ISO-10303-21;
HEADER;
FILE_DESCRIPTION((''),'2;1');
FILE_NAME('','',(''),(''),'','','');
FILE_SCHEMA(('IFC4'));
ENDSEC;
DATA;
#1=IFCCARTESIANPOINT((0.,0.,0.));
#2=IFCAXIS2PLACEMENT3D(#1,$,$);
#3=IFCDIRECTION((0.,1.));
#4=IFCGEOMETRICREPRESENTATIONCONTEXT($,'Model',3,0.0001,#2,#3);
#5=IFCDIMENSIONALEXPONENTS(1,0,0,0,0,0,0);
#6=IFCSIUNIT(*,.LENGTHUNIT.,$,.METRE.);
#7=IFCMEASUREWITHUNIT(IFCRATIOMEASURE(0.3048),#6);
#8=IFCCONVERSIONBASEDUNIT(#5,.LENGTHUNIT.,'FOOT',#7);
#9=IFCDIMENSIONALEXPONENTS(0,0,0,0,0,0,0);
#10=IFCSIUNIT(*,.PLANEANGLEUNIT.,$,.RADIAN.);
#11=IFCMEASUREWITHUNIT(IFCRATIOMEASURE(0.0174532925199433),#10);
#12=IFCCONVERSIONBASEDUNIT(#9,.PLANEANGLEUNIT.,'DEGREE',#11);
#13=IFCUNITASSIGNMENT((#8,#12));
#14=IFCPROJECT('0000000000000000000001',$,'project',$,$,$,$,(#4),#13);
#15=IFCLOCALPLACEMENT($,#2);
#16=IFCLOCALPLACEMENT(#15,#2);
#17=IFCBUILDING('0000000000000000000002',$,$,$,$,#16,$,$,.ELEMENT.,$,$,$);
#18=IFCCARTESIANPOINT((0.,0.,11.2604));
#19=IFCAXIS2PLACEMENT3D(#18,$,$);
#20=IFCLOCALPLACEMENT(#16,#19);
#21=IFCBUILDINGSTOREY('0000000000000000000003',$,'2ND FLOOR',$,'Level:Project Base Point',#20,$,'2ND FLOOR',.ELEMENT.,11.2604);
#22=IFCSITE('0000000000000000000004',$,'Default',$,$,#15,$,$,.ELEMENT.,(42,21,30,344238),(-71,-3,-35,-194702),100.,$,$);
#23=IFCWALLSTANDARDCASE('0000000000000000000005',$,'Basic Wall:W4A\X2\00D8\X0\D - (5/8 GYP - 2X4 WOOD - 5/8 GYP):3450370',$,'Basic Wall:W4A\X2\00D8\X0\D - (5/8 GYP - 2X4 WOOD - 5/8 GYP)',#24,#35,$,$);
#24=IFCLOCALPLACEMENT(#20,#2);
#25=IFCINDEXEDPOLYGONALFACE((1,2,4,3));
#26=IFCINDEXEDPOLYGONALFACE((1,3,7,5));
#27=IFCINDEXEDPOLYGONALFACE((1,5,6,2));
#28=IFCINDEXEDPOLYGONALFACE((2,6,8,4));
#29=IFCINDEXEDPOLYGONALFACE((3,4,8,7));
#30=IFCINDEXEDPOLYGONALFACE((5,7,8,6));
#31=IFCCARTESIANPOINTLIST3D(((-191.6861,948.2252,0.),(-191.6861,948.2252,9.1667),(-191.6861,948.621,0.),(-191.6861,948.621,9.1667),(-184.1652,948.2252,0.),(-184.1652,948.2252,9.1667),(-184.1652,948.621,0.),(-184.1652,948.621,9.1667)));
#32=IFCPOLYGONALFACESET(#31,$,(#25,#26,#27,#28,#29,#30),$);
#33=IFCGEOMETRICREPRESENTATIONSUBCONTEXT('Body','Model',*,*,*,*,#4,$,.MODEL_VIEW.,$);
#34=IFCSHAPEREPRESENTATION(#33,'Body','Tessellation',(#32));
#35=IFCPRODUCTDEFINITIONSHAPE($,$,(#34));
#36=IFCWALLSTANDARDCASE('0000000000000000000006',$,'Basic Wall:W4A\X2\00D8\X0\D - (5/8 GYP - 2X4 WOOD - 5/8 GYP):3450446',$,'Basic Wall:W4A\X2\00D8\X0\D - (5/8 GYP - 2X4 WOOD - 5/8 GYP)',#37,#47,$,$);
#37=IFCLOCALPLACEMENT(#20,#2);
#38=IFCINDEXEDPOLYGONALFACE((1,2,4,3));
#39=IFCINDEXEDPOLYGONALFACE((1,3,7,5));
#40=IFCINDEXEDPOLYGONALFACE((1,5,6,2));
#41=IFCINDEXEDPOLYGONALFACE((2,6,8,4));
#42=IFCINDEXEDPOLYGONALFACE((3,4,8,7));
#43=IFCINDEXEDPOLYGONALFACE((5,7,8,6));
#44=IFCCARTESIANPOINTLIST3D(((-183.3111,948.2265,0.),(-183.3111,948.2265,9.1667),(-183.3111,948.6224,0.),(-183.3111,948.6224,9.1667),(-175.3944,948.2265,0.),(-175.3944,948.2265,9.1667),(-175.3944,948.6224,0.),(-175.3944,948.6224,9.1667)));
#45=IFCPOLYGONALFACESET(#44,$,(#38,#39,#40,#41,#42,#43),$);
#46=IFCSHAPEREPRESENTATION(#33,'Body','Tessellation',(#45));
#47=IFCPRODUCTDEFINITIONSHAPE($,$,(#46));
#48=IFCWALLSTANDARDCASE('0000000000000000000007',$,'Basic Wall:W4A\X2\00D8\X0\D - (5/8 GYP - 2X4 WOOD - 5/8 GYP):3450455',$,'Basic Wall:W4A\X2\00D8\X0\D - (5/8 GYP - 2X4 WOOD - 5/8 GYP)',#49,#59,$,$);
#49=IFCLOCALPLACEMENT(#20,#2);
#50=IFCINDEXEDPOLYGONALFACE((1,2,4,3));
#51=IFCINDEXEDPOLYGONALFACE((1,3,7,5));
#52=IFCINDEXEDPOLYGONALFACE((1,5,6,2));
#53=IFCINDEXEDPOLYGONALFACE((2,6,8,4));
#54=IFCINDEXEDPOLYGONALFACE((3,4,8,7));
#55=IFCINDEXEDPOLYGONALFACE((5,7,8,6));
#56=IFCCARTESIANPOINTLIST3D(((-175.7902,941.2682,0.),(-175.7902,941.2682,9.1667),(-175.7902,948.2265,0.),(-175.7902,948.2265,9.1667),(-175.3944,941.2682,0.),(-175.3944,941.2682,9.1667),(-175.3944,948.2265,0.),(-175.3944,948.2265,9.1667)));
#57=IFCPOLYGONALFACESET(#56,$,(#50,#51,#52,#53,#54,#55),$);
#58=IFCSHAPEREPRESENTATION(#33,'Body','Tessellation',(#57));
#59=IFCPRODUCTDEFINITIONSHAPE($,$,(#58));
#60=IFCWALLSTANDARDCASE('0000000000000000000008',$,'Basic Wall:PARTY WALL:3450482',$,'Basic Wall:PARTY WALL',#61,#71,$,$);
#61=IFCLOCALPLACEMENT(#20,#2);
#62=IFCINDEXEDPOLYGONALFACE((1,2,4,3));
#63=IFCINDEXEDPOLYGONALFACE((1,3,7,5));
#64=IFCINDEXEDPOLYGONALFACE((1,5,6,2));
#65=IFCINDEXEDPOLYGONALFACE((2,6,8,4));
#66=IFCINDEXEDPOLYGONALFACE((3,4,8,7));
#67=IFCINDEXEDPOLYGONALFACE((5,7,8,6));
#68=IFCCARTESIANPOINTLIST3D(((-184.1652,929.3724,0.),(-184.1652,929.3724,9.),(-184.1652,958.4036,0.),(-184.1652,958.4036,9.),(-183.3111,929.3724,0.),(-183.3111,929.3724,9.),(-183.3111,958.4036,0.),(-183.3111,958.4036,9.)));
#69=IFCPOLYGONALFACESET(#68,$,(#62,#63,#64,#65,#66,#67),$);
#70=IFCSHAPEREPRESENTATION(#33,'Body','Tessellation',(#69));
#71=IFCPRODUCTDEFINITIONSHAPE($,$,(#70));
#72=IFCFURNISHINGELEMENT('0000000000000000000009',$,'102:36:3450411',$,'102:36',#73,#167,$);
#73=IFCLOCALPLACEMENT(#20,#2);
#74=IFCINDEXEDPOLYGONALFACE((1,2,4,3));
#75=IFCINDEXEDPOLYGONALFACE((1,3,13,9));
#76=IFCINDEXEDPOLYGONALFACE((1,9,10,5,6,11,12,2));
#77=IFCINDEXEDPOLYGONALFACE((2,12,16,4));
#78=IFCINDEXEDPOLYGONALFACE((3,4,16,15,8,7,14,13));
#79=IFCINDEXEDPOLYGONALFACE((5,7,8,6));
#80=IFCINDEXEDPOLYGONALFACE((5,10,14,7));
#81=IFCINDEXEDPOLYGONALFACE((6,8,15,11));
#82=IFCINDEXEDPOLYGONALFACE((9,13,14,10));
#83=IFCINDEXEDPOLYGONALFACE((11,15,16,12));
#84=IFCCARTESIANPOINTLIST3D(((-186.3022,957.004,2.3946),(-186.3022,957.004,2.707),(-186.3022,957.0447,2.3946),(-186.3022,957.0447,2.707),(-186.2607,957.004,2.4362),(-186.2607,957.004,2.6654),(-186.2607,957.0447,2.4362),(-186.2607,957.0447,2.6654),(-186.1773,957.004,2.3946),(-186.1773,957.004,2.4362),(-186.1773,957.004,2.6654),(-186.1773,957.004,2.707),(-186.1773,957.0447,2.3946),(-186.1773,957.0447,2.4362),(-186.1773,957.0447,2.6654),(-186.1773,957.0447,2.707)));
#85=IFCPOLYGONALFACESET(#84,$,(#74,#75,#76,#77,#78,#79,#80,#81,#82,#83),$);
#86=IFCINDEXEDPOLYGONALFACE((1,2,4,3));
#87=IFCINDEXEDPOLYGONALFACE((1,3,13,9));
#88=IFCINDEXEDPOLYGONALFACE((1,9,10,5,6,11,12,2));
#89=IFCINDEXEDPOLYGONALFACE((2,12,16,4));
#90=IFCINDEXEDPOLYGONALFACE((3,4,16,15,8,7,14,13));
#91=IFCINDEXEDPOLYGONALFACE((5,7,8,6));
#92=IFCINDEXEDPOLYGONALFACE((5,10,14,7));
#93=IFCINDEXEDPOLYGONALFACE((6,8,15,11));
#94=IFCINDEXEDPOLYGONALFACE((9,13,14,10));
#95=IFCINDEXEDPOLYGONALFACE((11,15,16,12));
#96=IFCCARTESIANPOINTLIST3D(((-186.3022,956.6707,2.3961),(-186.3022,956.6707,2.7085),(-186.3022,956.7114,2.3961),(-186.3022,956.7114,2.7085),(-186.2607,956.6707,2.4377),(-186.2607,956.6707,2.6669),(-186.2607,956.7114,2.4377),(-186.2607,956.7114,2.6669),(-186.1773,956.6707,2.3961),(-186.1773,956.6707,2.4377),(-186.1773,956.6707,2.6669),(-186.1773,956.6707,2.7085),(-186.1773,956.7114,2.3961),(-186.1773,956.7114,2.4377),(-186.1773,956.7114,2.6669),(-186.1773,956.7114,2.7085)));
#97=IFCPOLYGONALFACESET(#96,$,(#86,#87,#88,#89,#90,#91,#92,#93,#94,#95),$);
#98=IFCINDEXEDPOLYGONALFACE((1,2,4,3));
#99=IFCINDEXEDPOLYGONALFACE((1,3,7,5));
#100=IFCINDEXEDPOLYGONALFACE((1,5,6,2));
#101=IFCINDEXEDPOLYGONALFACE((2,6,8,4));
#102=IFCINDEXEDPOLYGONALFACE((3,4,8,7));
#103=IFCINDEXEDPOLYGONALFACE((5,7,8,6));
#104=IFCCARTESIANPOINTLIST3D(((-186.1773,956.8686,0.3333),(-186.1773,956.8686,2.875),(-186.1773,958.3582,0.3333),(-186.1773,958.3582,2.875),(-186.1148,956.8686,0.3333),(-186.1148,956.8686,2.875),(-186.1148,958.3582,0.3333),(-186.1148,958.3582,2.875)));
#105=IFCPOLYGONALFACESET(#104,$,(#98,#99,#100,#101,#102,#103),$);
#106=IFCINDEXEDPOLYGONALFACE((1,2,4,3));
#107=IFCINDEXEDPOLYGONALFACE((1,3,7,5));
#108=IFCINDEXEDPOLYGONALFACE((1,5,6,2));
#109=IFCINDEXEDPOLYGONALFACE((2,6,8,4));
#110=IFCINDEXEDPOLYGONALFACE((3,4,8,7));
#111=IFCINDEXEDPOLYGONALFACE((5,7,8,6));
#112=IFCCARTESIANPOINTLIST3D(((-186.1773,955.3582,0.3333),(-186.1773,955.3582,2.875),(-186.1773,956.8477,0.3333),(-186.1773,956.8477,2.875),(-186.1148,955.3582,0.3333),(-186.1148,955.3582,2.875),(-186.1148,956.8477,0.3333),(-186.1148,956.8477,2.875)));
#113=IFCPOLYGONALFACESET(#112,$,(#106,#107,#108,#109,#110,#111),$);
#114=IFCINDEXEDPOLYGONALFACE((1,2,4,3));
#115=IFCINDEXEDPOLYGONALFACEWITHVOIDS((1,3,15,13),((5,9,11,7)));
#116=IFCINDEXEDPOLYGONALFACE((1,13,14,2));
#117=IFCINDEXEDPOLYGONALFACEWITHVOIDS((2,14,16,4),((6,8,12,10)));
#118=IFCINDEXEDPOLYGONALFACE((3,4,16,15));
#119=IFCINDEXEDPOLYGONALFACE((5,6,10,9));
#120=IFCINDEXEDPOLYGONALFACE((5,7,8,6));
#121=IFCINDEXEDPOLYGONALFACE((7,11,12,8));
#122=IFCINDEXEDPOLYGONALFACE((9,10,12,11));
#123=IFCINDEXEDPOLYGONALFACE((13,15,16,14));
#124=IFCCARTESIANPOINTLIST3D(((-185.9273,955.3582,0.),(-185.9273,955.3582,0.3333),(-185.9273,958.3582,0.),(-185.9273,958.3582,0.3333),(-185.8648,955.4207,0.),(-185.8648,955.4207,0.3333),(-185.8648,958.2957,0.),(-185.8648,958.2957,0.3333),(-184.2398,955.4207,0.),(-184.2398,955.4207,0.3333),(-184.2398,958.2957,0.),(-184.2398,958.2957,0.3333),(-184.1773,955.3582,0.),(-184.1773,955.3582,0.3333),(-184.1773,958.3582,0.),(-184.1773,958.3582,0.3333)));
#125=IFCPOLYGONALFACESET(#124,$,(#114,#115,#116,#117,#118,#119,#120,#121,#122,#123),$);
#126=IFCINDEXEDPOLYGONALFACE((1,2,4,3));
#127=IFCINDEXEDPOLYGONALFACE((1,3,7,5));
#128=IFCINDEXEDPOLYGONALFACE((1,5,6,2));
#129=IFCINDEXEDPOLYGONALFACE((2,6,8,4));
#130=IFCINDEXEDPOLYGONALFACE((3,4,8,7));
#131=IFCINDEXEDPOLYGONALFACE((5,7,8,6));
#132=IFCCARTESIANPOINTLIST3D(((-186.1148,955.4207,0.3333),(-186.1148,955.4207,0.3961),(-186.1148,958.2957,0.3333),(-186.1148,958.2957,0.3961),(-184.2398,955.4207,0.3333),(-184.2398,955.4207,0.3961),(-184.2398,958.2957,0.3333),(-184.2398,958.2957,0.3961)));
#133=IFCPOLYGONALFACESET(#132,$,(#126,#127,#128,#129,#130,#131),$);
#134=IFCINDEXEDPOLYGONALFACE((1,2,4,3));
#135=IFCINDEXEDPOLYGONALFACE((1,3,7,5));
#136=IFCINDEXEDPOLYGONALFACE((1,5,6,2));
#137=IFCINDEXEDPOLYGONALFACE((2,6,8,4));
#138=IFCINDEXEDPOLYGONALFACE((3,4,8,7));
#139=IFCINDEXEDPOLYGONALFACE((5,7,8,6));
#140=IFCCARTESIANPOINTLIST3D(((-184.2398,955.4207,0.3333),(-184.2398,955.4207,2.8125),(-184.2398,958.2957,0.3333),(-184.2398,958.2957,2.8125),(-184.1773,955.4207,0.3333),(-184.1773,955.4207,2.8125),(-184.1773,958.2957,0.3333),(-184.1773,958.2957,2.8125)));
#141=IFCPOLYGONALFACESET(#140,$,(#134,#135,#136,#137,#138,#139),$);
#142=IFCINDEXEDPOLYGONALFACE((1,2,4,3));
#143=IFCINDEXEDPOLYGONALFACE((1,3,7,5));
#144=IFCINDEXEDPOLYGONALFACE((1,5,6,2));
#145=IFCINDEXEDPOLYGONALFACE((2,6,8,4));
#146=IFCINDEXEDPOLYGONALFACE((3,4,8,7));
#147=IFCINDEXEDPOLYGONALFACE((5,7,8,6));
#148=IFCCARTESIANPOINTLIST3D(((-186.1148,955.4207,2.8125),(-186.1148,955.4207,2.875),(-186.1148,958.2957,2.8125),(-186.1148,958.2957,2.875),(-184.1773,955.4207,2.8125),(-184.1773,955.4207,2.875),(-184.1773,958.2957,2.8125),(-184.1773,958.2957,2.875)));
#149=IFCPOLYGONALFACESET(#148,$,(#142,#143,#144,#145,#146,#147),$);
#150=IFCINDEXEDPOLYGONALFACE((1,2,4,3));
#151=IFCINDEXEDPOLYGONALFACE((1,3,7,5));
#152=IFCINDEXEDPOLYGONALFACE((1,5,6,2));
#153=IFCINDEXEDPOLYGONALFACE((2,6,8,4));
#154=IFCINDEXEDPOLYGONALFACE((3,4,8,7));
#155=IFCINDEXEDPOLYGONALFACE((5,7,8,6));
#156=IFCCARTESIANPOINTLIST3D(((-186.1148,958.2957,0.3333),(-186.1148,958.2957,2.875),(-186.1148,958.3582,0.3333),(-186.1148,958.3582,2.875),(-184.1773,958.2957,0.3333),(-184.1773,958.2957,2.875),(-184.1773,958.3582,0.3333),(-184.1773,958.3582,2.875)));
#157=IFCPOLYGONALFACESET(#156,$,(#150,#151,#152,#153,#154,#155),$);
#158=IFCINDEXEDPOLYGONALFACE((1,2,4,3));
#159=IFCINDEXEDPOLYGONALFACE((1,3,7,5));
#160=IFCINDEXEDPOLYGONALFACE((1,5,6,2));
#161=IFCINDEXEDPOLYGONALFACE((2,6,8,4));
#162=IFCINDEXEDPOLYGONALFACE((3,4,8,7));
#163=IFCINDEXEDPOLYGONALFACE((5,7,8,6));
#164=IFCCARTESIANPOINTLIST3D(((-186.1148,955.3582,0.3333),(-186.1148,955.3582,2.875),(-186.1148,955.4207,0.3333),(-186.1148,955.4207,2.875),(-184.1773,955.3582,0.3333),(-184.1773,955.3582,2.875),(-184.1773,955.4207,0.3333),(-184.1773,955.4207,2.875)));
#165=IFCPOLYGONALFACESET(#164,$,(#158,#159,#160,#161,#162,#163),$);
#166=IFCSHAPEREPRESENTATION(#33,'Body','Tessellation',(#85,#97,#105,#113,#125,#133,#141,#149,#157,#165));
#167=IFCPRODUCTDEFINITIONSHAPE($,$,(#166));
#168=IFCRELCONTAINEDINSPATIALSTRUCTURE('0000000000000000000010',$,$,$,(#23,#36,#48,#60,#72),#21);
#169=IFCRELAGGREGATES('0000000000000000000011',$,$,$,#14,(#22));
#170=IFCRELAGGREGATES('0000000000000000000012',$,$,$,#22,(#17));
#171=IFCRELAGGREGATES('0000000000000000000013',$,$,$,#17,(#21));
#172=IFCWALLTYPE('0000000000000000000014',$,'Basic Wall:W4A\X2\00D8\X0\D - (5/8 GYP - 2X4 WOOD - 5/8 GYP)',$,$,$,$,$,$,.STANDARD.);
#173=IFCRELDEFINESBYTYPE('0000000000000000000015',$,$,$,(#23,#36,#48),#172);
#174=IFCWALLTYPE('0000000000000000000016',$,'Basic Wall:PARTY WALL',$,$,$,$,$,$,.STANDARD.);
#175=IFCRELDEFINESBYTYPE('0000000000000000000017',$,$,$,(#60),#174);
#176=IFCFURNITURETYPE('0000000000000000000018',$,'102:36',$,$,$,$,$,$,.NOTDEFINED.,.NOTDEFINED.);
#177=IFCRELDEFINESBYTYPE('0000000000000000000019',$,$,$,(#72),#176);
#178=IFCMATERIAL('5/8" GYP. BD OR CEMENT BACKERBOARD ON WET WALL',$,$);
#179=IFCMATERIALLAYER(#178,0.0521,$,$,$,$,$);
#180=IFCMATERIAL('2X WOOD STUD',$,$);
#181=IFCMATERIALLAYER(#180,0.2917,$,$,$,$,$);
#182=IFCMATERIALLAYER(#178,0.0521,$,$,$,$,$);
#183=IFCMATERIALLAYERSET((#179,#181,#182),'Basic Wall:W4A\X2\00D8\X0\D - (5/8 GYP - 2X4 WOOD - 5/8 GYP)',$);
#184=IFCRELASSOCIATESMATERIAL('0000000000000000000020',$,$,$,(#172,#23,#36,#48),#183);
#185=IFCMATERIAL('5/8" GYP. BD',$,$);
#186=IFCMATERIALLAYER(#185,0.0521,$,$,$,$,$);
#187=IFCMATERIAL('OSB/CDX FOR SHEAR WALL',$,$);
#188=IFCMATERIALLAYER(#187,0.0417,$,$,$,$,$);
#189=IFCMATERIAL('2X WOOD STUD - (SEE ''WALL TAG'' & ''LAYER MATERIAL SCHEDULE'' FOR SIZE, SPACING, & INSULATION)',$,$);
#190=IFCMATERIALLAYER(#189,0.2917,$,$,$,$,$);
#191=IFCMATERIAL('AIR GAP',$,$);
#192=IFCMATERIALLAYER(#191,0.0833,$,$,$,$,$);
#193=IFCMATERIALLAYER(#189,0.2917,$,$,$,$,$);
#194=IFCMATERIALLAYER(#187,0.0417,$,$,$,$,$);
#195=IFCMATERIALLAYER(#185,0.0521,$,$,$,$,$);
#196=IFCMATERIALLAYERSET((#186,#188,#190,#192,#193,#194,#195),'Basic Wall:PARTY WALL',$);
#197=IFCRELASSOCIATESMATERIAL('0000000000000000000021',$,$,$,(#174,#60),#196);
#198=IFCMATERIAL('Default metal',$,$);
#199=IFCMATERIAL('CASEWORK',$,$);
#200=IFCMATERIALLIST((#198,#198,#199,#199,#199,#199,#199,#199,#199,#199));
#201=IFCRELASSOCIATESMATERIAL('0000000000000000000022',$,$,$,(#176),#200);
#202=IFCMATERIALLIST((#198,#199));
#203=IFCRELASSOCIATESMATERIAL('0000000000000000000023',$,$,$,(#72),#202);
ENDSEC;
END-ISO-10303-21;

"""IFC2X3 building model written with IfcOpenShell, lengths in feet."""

from ifc_helpers import new_model, entity, si_unit, converted_unit, direction, frame, frame_2d, origin, origin_2d_with_axis, place, context, subcontext, project, spatial, polyline, rectangle, outline, extrude, source, transform, mapped, material, material_list, layer, layer_set, layer_usage, type_object, type_shapes, element, save


model = new_model("IFC2X3")

# Units and contexts
model_context = context("Model", 3, precision=0.0001, world=origin(), true_north=direction((0.0, 1.0)))
body_context = subcontext(model_context, "Body", "Model", "MODEL_VIEW")
ifc_project = project(units=[converted_unit("LENGTHUNIT", "FOOT", entity("IfcRatioMeasure", 0.3048), si_unit("LENGTHUNIT", "METRE"), dimensions=[1, 0, 0, 0, 0, 0, 0]), converted_unit("PLANEANGLEUNIT", "DEGREE", entity("IfcRatioMeasure", 0.0174532925199433), si_unit("PLANEANGLEUNIT", "RADIAN"), dimensions=[0, 0, 0, 0, 0, 0, 0])], contexts=[model_context])

# Site, building, storey
site_placement = place(None, origin())
site = spatial("IfcSite", under=ifc_project, at=site_placement, Name="Default", CompositionType="ELEMENT", RefLatitude=(42, 21, 30, 344238), RefLongitude=(-71, -3, -35, -194702), RefElevation=100.0)
building_placement = place(site_placement, origin())
building = spatial("IfcBuilding", under=site, at=building_placement, CompositionType="ELEMENT")
storey_placement = place(building_placement, frame((0.0, 0.0, 11.2604)))
storey = spatial("IfcBuildingStorey", under=building, at=storey_placement, Name="2ND FLOOR", ObjectType="Level:Project Base Point", LongName="2ND FLOOR", CompositionType="ELEMENT", Elevation=11.2604)

# Wall
ifc_material_1 = material(Name="5/8\" GYP. BD OR CEMENT BACKERBOARD ON WET WALL")
ifc_layer_1 = layer(ifc_material_1, 0.0521)
ifc_material_2 = material(Name="2X WOOD STUD")
ifc_layer_2 = layer(ifc_material_2, 0.2917)
ifc_layer_3 = layer(ifc_material_1, 0.0521)
ifc_layer_set_1 = layer_set([ifc_layer_1, ifc_layer_2, ifc_layer_3], Name="Basic Wall:W4AØD - (5/8 GYP - 2X4 WOOD - 5/8 GYP)")
ifc_layer_usage_1 = layer_usage(ifc_layer_set_1, "AXIS2", "NEGATIVE", 0.1979)
wall_type_1 = type_object("IfcWallType", Name="Basic Wall:W4AØD - (5/8 GYP - 2X4 WOOD - 5/8 GYP)", PredefinedType="STANDARD", material=ifc_layer_set_1)
wall_1_placement = place(storey_placement, frame((-184.1652, 948.4231, 0.0), z_axis=(0.0, 0.0, 1.0), x_axis=(-1.0, 0.0, 0.0)))
element("IfcWallStandardCase", 1, at=wall_1_placement, inside=storey, type_object=wall_type_1, material=ifc_layer_usage_1, Name="Basic Wall:W4AØD - (5/8 GYP - 2X4 WOOD - 5/8 GYP):3450370", ObjectType="Basic Wall:W4AØD - (5/8 GYP - 2X4 WOOD - 5/8 GYP)", context=body_context, shape_type="SweptSolid", body=[
    extrude(rectangle(XDim=7.5208, YDim=0.3958, at=frame_2d((3.7604, 0.0), x_axis=(-1.0, 0.0))), origin(), (0.0, 0.0, 1.0), 9.1667),
])

# Wall
ifc_layer_usage_2 = layer_usage(ifc_layer_set_1, "AXIS2", "POSITIVE", -0.1979)
wall_2_placement = place(storey_placement, frame((-183.3111, 948.4244, 0.0)))
element("IfcWallStandardCase", 2, at=wall_2_placement, inside=storey, type_object=wall_type_1, material=ifc_layer_usage_2, Name="Basic Wall:W4AØD - (5/8 GYP - 2X4 WOOD - 5/8 GYP):3450446", ObjectType="Basic Wall:W4AØD - (5/8 GYP - 2X4 WOOD - 5/8 GYP)", context=body_context, shape_type="SweptSolid", body=[
    extrude(rectangle(XDim=7.9167, YDim=0.3958, at=frame_2d((3.9583, 0.0), x_axis=(-1.0, 0.0))), origin(), (0.0, 0.0, 1.0), 9.1667),
])

# Walls
ifc_layer_usage_3 = layer_usage(ifc_layer_set_1, "AXIS2", "POSITIVE", -0.1979)
wall_3_placement = place(storey_placement, frame((-175.5923, 941.2682, 0.0), z_axis=(0.0, 0.0, 1.0), x_axis=(0.0, 1.0, 0.0)))
element("IfcWallStandardCase", 3, at=wall_3_placement, inside=storey, type_object=wall_type_1, material=ifc_layer_usage_3, Name="Basic Wall:W4AØD - (5/8 GYP - 2X4 WOOD - 5/8 GYP):3450455", ObjectType="Basic Wall:W4AØD - (5/8 GYP - 2X4 WOOD - 5/8 GYP)", context=body_context, shape_type="SweptSolid", body=[
    extrude(rectangle(XDim=6.9583, YDim=0.3958, at=frame_2d((3.4792, 0.0), x_axis=(-1.0, 0.0))), origin(), (0.0, 0.0, 1.0), 9.1667),
])
ifc_material_3 = material(Name="5/8\" GYP. BD")
ifc_layer_4 = layer(ifc_material_3, 0.0521)
ifc_material_4 = material(Name="OSB/CDX FOR SHEAR WALL")
ifc_layer_5 = layer(ifc_material_4, 0.0417)
ifc_material_5 = material(Name="2X WOOD STUD - (SEE 'WALL TAG' & 'LAYER MATERIAL SCHEDULE' FOR SIZE, SPACING, & INSULATION)")
ifc_layer_6 = layer(ifc_material_5, 0.2917)
ifc_material_6 = material(Name="AIR GAP")
ifc_layer_7 = layer(ifc_material_6, 0.0833)
ifc_layer_8 = layer(ifc_material_5, 0.2917)
ifc_layer_9 = layer(ifc_material_4, 0.0417)
ifc_layer_10 = layer(ifc_material_3, 0.0521)
ifc_layer_set_2 = layer_set([ifc_layer_4, ifc_layer_5, ifc_layer_6, ifc_layer_7, ifc_layer_8, ifc_layer_9, ifc_layer_10], Name="Basic Wall:PARTY WALL")
ifc_layer_usage_4 = layer_usage(ifc_layer_set_2, "AXIS2", "POSITIVE", -0.4271)
wall_type_2 = type_object("IfcWallType", Name="Basic Wall:PARTY WALL", PredefinedType="STANDARD", material=ifc_layer_set_2)
wall_4_placement = place(storey_placement, frame((-183.7382, 929.3724, 0.0), z_axis=(0.0, 0.0, 1.0), x_axis=(0.0, 1.0, 0.0)))
element("IfcWallStandardCase", 4, at=wall_4_placement, inside=storey, type_object=wall_type_2, material=ifc_layer_usage_4, Name="Basic Wall:PARTY WALL:3450482", ObjectType="Basic Wall:PARTY WALL", context=body_context, shape_type="SweptSolid", body=[
    extrude(rectangle(XDim=29.0313, YDim=0.8542, at=frame_2d((14.5156, 0.0), x_axis=(-1.0, 0.0))), origin(), (0.0, 0.0, 1.0), 9.0),
])

# Furnishing element
ifc_material_7 = material(Name="Default metal")
ifc_material_8 = material(Name="CASEWORK")
ifc_material_list_1 = material_list([ifc_material_7, ifc_material_8])
ifc_material_list_2 = material_list([ifc_material_7, ifc_material_7, ifc_material_8, ifc_material_8, ifc_material_8, ifc_material_8, ifc_material_8, ifc_material_8, ifc_material_8, ifc_material_8])
furniture_type_1 = type_object("IfcFurnitureType", Name="102:36", material=ifc_material_list_2)
shared_shape_1 = source(origin(), body_context, "Body", "SweptSolid", [
    extrude(outline(polyline([(-0.0521, -0.1146), (-0.0521, -0.1562), (0.0729, -0.1562), (0.0729, 0.1562), (-0.0521, 0.1562), (-0.0521, 0.1146), (0.0313, 0.1146), (0.0313, -0.1146), (-0.0521, -0.1146)])), frame((0.2073, 2.0521, 2.5508), z_axis=(-1.0, 0.0, 0.0), x_axis=(0.0, 1.0, 0.0)), (0.0, 0.0, -1.0), 0.0407),
    extrude(outline(polyline([(-0.0521, -0.1146), (-0.0521, -0.1562), (0.0729, -0.1562), (0.0729, 0.1562), (-0.0521, 0.1562), (-0.0521, 0.1146), (0.0313, 0.1146), (0.0313, -0.1146), (-0.0521, -0.1146)])), frame((-0.126, 2.0521, 2.5523), z_axis=(-1.0, 0.0, 0.0), x_axis=(0.0, 1.0, 0.0)), (0.0, 0.0, -1.0), 0.0407),
    extrude(rectangle(XDim=1.4896, YDim=0.0625, at=frame_2d((0.0, 0.0), x_axis=(1.0, 0.0))), frame((0.8167, 1.9688, 0.3333), z_axis=(0.0, 0.0, 1.0), x_axis=(-1.0, 0.0, 0.0)), (0.0, 0.0, 1.0), 2.5417),
    extrude(rectangle(XDim=1.4896, YDim=0.0625, at=origin_2d_with_axis()), frame((-0.6937, 1.9688, 0.3333), z_axis=(0.0, 0.0, 1.0), x_axis=(-1.0, 0.0, 0.0)), (0.0, 0.0, 1.0), 2.5417),
    extrude(outline(polyline([(-0.875, -1.5), (0.875, -1.5), (0.875, 1.5), (-0.875, 1.5), (-0.875, -1.5)]), holes=[polyline([(-0.8125, -1.4375), (-0.8125, 1.4375), (0.8125, 1.4375), (0.8125, -1.4375), (-0.8125, -1.4375)])]), frame((0.0615, 0.875, 0.0), z_axis=(0.0, 0.0, 1.0), x_axis=(0.0, -1.0, 0.0)), (0.0, 0.0, 1.0), 0.3333),
    extrude(rectangle(XDim=1.875, YDim=2.875, at=origin_2d_with_axis()), frame((0.0615, 1.0, 0.3333), z_axis=(0.0, 0.0, 1.0), x_axis=(0.0, 1.0, 0.0)), (0.0, 0.0, 1.0), 0.0627),
    extrude(rectangle(XDim=2.875, YDim=0.0625, at=origin_2d_with_axis()), frame((0.0615, 0.0312, 0.3333), z_axis=(0.0, 0.0, 1.0), x_axis=(-1.0, 0.0, 0.0)), (0.0, 0.0, 1.0), 2.4792),
    extrude(rectangle(XDim=1.9375, YDim=2.875, at=frame_2d((0.0, 0.0), x_axis=(1.0, 0.0))), frame((0.0615, 0.9688, 2.8125), z_axis=(0.0, 0.0, 1.0), x_axis=(0.0, 1.0, 0.0)), (0.0, 0.0, 1.0), 0.0625),
    extrude(rectangle(XDim=1.9375, YDim=0.0625, at=frame_2d((0.0, 0.0), x_axis=(1.0, 0.0))), frame((1.5302, 0.9687, 0.3333), z_axis=(0.0, 0.0, 1.0), x_axis=(0.0, -1.0, 0.0)), (0.0, 0.0, 1.0), 2.5417),
    extrude(rectangle(XDim=1.9375, YDim=0.0625, at=frame_2d((0.0, 0.0), x_axis=(1.0, 0.0))), frame((-1.4073, 0.9687, 0.3333), z_axis=(0.0, 0.0, 1.0), x_axis=(0.0, -1.0, 0.0)), (0.0, 0.0, 1.0), 2.5417),
])
type_shapes(furniture_type_1, [shared_shape_1])
furnishing_1_placement = place(storey_placement, frame((-184.1773, 956.7967, 0.0), z_axis=(0.0, 0.0, 1.0), x_axis=(0.0, 1.0, 0.0)))
element("IfcFurnishingElement", 5, at=furnishing_1_placement, inside=storey, type_object=furniture_type_1, material=ifc_material_list_1, Name="102:36:3450411", ObjectType="102:36", context=body_context, shape_type="MappedRepresentation", body=[
    mapped(shared_shape_1, transform((0.0, 0.0, 0.0), scale=1.0)),
])

save(model, "model.ifc")
